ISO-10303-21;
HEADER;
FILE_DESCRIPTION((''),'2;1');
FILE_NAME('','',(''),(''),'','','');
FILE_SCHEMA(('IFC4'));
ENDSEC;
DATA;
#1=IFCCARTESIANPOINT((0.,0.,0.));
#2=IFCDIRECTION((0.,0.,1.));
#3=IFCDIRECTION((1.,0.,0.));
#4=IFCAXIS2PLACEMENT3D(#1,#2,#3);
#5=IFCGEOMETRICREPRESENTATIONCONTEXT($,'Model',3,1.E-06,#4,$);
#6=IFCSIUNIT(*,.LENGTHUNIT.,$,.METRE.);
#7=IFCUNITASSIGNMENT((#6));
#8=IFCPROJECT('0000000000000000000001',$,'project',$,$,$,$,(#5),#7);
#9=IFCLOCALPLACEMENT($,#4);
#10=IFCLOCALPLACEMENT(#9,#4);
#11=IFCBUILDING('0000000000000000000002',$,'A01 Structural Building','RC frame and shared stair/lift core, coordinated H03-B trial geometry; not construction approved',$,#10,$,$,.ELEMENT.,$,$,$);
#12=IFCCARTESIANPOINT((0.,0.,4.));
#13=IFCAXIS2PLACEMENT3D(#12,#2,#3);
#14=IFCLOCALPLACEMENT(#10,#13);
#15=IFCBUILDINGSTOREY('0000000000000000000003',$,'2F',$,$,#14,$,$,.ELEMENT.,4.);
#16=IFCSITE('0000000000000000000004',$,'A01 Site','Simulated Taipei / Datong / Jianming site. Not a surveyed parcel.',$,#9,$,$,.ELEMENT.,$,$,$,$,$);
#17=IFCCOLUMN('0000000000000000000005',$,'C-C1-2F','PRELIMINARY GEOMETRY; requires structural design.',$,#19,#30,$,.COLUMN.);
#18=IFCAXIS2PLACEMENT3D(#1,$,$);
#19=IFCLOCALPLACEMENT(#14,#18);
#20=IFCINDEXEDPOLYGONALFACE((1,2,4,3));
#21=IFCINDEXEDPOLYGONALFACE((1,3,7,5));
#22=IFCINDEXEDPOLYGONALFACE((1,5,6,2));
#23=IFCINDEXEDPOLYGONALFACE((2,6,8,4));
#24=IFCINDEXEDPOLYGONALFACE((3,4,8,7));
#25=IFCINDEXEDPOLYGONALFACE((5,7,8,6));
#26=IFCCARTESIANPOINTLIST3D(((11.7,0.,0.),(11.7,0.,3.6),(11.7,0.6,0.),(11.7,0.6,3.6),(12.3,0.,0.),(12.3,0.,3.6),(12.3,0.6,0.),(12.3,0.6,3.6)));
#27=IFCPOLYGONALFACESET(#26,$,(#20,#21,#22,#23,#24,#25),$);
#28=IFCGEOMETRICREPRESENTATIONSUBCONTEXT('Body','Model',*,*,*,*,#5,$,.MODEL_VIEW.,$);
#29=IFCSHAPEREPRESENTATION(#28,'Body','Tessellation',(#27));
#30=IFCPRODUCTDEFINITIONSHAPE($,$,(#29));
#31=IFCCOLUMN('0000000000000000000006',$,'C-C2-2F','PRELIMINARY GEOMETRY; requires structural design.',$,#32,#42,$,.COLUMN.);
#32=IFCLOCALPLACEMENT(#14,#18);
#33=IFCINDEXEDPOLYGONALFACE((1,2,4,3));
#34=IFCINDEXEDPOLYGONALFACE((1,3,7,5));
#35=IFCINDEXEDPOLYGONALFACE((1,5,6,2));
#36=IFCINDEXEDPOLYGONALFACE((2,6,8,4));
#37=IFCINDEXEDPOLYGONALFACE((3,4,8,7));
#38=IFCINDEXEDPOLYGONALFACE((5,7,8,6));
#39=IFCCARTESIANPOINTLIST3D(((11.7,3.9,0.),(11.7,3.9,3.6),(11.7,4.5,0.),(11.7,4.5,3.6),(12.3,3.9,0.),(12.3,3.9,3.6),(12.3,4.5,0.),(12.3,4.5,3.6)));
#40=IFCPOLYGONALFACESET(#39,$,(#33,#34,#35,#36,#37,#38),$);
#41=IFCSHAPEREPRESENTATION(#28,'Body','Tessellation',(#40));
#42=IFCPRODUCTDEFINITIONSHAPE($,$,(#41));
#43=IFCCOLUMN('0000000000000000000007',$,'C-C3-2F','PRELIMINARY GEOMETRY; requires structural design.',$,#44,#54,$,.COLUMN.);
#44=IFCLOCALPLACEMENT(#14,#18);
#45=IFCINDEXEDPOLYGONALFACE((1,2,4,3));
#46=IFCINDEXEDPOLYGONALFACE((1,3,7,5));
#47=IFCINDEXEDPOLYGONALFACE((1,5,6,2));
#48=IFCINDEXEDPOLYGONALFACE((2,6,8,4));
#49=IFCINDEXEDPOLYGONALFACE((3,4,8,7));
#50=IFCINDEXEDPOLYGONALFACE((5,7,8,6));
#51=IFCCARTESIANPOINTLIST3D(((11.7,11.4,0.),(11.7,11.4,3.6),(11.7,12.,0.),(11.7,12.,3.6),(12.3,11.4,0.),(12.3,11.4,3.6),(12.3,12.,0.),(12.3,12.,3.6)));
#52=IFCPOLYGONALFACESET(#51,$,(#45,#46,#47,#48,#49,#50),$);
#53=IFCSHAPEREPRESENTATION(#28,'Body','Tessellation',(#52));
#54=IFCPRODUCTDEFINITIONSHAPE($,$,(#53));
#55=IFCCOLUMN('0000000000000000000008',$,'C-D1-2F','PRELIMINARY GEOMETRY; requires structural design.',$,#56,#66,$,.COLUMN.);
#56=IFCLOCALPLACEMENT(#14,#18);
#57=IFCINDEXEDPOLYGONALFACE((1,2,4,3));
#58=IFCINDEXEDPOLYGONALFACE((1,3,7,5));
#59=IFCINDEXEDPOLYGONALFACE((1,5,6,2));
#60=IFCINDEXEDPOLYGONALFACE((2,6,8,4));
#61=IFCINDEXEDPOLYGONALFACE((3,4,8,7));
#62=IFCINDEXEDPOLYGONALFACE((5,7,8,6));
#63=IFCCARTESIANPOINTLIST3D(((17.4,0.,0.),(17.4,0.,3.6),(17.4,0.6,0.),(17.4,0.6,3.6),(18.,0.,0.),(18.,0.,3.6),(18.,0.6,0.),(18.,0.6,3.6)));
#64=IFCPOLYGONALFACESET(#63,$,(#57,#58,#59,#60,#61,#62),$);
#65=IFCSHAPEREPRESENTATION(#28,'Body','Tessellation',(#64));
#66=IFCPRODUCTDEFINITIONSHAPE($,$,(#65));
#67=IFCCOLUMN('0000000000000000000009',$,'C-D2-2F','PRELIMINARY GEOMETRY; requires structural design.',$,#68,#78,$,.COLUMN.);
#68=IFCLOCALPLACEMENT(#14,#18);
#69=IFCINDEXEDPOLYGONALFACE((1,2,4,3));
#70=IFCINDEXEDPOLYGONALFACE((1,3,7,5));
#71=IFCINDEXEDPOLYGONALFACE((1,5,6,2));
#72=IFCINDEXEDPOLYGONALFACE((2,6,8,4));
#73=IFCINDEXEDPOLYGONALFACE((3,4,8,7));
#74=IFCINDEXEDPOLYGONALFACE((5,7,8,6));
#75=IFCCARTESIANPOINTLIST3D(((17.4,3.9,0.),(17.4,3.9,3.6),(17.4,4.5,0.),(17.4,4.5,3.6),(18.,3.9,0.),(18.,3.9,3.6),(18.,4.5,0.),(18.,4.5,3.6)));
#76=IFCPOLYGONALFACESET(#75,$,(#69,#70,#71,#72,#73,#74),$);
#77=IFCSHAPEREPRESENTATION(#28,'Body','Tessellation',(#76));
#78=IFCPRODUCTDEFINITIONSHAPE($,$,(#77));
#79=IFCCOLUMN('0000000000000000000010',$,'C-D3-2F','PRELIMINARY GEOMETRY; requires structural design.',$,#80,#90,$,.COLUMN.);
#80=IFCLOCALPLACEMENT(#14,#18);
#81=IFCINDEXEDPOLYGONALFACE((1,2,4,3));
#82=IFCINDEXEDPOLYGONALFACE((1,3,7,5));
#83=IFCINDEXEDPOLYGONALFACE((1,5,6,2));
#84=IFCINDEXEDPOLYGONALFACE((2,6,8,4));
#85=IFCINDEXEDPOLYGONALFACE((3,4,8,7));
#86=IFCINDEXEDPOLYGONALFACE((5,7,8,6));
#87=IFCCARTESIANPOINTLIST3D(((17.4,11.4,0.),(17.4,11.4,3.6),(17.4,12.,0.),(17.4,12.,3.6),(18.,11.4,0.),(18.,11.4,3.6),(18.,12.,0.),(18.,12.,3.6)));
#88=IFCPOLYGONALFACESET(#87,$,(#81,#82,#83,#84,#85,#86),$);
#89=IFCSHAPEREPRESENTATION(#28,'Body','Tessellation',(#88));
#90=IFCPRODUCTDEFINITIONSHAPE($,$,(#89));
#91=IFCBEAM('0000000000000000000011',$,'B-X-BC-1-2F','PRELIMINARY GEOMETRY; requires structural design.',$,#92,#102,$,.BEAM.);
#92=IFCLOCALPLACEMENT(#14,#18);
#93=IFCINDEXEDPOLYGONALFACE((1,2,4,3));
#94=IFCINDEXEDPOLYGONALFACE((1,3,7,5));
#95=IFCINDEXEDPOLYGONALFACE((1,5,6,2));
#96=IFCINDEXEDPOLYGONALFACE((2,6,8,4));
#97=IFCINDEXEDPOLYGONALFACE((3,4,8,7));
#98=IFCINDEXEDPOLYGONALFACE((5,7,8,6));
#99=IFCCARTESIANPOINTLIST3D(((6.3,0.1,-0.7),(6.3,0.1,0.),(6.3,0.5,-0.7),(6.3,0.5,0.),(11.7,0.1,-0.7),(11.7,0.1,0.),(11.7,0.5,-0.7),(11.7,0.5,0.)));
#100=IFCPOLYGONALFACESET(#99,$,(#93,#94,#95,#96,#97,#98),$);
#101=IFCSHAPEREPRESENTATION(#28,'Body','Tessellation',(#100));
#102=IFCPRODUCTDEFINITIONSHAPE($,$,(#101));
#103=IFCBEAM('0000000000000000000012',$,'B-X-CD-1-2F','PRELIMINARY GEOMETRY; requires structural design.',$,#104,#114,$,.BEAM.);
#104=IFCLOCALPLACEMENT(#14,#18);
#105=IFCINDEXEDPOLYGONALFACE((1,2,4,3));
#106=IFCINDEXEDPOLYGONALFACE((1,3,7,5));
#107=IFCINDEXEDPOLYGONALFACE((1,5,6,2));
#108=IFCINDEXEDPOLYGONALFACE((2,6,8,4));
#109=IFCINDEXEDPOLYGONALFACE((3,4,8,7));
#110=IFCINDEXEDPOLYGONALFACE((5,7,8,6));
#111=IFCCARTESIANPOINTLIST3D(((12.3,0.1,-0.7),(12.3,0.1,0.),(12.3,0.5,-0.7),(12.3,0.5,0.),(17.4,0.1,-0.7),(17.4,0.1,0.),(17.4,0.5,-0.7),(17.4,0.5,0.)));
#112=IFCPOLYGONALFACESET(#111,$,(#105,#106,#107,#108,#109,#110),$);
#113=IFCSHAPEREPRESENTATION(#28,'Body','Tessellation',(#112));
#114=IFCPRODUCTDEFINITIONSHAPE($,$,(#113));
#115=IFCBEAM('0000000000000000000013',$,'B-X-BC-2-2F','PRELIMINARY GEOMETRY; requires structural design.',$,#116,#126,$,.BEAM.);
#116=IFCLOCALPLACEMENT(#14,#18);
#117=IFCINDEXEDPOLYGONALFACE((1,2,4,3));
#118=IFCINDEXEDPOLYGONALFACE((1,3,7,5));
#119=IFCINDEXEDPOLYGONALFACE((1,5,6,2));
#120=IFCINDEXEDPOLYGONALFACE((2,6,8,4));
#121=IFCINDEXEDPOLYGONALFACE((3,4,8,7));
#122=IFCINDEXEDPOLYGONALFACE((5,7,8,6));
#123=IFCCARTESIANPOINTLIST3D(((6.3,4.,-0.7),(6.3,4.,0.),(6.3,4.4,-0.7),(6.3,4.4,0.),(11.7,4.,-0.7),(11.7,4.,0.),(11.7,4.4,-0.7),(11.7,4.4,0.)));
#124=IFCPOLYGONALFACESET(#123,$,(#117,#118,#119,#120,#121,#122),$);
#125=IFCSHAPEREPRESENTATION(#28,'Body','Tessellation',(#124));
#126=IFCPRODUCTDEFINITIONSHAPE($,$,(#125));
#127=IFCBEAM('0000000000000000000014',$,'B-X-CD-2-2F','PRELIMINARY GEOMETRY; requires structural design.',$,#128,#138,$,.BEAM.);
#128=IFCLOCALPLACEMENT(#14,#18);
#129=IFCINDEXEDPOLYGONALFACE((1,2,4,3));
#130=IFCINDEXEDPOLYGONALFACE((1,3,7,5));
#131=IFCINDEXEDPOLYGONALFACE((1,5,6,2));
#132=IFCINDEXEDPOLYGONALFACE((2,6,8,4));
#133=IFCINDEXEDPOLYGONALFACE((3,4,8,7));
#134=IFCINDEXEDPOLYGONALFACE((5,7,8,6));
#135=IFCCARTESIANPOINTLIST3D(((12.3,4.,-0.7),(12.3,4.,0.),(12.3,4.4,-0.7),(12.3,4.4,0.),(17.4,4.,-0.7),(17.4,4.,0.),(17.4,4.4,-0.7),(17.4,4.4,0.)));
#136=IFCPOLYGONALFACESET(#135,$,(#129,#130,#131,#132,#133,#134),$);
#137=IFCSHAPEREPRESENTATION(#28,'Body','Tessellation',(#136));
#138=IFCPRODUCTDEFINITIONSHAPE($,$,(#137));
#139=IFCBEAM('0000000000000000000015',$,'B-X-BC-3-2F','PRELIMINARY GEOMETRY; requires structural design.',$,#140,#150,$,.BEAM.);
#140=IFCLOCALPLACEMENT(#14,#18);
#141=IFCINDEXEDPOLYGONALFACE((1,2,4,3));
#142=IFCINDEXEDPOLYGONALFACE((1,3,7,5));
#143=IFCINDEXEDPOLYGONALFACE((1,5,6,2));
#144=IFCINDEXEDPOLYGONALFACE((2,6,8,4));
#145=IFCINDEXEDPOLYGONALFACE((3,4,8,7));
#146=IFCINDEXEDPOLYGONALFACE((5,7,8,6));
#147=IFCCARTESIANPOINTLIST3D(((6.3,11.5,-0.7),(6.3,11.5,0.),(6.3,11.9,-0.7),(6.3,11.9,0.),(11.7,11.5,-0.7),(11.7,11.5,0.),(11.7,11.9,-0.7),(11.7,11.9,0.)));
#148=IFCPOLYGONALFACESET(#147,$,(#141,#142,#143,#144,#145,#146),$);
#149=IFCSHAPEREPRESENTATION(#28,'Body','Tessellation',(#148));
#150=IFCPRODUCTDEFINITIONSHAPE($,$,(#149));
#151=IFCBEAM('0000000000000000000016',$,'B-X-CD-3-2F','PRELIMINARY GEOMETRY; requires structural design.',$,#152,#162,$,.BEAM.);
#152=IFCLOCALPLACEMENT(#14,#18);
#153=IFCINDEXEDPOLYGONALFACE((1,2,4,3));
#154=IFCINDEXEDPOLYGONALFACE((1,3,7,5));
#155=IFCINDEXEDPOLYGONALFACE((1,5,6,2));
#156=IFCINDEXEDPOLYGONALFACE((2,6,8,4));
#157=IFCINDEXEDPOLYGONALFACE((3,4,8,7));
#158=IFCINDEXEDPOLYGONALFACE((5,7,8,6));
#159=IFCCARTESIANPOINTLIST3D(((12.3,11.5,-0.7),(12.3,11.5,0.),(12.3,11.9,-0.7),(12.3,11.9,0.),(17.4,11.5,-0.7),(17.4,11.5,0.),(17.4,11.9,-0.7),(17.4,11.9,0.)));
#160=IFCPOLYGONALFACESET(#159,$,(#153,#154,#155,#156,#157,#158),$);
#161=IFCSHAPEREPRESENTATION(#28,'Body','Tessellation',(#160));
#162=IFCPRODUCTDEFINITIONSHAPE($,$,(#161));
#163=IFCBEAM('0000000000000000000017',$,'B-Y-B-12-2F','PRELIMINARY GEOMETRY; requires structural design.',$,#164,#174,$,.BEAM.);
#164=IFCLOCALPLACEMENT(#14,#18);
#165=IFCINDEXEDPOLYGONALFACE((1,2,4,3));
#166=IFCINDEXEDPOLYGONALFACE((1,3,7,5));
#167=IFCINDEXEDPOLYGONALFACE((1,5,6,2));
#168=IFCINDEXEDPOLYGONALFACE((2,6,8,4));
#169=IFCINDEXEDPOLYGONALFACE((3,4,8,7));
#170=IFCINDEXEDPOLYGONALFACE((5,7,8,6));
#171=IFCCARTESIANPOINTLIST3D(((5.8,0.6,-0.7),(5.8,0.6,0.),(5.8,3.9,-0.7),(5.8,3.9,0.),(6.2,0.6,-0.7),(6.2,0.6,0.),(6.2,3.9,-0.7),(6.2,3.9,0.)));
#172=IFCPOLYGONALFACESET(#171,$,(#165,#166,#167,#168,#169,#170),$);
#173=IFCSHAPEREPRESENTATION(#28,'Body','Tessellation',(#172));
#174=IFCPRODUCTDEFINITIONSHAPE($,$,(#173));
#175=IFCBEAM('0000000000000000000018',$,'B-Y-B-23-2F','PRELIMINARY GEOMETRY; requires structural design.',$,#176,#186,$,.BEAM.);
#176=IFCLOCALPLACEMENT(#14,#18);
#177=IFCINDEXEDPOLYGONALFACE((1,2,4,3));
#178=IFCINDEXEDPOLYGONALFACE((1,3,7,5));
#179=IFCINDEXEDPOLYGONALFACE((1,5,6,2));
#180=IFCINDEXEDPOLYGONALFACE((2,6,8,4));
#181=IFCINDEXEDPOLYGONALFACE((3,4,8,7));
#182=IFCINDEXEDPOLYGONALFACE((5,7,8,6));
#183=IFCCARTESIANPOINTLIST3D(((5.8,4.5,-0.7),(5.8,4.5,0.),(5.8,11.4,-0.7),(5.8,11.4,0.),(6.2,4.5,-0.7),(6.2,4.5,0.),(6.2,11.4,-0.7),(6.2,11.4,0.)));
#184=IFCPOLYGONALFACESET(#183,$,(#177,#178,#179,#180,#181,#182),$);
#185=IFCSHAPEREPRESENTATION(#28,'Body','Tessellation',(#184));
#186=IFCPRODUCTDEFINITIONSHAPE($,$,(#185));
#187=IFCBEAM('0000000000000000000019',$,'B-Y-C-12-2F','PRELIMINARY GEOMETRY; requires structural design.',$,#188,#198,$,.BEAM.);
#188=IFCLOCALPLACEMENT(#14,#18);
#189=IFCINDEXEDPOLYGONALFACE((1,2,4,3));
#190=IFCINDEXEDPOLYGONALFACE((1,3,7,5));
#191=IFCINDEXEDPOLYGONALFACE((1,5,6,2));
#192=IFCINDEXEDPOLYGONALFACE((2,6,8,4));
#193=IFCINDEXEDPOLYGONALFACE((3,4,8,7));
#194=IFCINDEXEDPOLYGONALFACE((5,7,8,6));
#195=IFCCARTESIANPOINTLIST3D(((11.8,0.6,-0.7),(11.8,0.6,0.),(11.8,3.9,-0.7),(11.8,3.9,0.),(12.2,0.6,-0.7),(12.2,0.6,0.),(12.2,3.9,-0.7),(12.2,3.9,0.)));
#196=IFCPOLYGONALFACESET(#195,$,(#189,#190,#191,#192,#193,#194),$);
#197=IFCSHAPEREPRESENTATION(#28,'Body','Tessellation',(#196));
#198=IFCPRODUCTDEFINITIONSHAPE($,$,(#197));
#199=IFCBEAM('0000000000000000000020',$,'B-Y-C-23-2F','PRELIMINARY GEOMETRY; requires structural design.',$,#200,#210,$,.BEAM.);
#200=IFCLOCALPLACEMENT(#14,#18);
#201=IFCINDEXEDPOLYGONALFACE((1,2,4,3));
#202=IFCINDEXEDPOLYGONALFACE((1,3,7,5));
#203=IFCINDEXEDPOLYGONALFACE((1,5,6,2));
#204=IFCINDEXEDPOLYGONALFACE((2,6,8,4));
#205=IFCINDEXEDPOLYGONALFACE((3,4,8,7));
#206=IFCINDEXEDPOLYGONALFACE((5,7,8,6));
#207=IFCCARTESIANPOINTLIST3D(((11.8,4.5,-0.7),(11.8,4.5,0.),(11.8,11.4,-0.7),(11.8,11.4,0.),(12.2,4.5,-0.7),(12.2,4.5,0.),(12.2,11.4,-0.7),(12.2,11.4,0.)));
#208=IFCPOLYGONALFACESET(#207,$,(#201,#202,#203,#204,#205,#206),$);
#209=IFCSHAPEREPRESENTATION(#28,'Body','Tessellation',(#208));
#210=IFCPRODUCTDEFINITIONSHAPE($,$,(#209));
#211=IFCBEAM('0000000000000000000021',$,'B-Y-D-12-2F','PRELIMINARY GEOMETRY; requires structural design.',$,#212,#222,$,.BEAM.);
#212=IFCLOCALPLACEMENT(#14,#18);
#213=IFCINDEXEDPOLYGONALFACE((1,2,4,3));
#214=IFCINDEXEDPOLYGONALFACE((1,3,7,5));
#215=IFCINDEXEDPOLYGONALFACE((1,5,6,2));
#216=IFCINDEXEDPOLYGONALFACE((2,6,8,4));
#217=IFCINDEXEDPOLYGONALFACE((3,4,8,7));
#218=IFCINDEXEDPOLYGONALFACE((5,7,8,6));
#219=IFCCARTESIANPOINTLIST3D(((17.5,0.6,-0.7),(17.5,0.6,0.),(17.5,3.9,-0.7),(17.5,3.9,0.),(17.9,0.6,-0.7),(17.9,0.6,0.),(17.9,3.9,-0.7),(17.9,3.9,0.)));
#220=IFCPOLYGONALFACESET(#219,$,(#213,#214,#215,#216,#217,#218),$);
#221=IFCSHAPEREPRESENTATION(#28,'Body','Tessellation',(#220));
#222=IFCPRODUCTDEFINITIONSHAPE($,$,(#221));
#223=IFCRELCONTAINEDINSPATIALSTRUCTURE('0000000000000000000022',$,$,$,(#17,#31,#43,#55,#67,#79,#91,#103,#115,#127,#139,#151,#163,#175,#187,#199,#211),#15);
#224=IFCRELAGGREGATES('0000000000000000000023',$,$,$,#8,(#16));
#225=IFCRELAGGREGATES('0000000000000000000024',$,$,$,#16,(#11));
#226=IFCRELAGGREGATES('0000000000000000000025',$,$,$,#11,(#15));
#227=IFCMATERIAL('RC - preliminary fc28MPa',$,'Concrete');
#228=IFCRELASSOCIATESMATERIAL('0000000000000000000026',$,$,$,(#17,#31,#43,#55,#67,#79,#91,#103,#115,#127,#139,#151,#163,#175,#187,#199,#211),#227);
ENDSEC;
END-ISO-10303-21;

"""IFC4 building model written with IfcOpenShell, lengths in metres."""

from ifc_helpers import new_model, si_unit, frame, origin_with_axes, place, context, subcontext, project, spatial, rectangle, extrude, material, element, save


model = new_model("IFC4")

# Units and contexts
model_context = context("Model", 3, precision=1e-06, world=origin_with_axes())
body_context = subcontext(model_context, "Body", "Model", "MODEL_VIEW")
ifc_project = project(units=[si_unit("LENGTHUNIT", "METRE")], contexts=[model_context])

# Site, building, storey
site_placement = place(None, origin_with_axes())
site = spatial("IfcSite", under=ifc_project, at=site_placement, Name="A01 Site", Description="Simulated Taipei / Datong / Jianming site. Not a surveyed parcel.", CompositionType="ELEMENT")
building_placement = place(site_placement, origin_with_axes())
building = spatial("IfcBuilding", under=site, at=building_placement, Name="A01 Structural Building", Description="RC frame and shared stair/lift core, coordinated H03-B trial geometry; not construction approved", CompositionType="ELEMENT")
storey_placement = place(building_placement, frame((0.0, 0.0, 4.0), z_axis=(0.0, 0.0, 1.0), x_axis=(1.0, 0.0, 0.0)))
storey = spatial("IfcBuildingStorey", under=building, at=storey_placement, Name="2F", CompositionType="ELEMENT", Elevation=4.0)

# Columns
ifc_material = material(Name="RC - preliminary fc28MPa", Category="Concrete")
for number, where, z_axis, x_axis, name in (
    (1, (12.0, 0.3, 0.0), (0.0, 0.0, 1.0), (1.0, 0.0, 0.0), "C-C1-2F"),
    (2, (12.0, 4.2, 0.0), (0.0, 0.0, 1.0), (1.0, 0.0, 0.0), "C-C2-2F"),
    (3, (12.0, 11.7, 0.0), (0.0, 0.0, 1.0), (1.0, 0.0, 0.0), "C-C3-2F"),
    (4, (17.7, 0.3, 0.0), (0.0, 0.0, 1.0), (1.0, 0.0, 0.0), "C-D1-2F"),
    (5, (17.7, 4.2, 0.0), (0.0, 0.0, 1.0), (1.0, 0.0, 0.0), "C-D2-2F"),
    (6, (17.7, 11.7, 0.0), (0.0, 0.0, 1.0), (1.0, 0.0, 0.0), "C-D3-2F"),
):
    element("IfcColumn", number, at=place(storey_placement, frame(where, z_axis=z_axis, x_axis=x_axis)), inside=storey, material=ifc_material, Name=name, Description="PRELIMINARY GEOMETRY; requires structural design.", PredefinedType="COLUMN", context=body_context, shape_type="SweptSolid", body=[
        extrude(rectangle(XDim=0.6, YDim=0.6), origin_with_axes(), (0.0, 0.0, 1.0), 3.6),
    ])

# Beams
beam_1_placement = place(storey_placement, frame((9.0, 0.3, -0.7), z_axis=(0.0, 0.0, 1.0), x_axis=(1.0, 0.0, 0.0)))
element("IfcBeam", 7, at=beam_1_placement, inside=storey, material=ifc_material, Name="B-X-BC-1-2F", Description="PRELIMINARY GEOMETRY; requires structural design.", PredefinedType="BEAM", context=body_context, shape_type="SweptSolid", body=[
    extrude(rectangle(XDim=5.4, YDim=0.4), origin_with_axes(), (0.0, 0.0, 1.0), 0.7),
])
beam_2_placement = place(storey_placement, frame((14.85, 0.3, -0.7), z_axis=(0.0, 0.0, 1.0), x_axis=(1.0, 0.0, 0.0)))
element("IfcBeam", 8, at=beam_2_placement, inside=storey, material=ifc_material, Name="B-X-CD-1-2F", Description="PRELIMINARY GEOMETRY; requires structural design.", PredefinedType="BEAM", context=body_context, shape_type="SweptSolid", body=[
    extrude(rectangle(XDim=5.1, YDim=0.4), origin_with_axes(), (0.0, 0.0, 1.0), 0.7),
])
beam_3_placement = place(storey_placement, frame((9.0, 4.2, -0.7), z_axis=(0.0, 0.0, 1.0), x_axis=(1.0, 0.0, 0.0)))
element("IfcBeam", 9, at=beam_3_placement, inside=storey, material=ifc_material, Name="B-X-BC-2-2F", Description="PRELIMINARY GEOMETRY; requires structural design.", PredefinedType="BEAM", context=body_context, shape_type="SweptSolid", body=[
    extrude(rectangle(XDim=5.4, YDim=0.4), origin_with_axes(), (0.0, 0.0, 1.0), 0.7),
])
beam_4_placement = place(storey_placement, frame((14.85, 4.2, -0.7), z_axis=(0.0, 0.0, 1.0), x_axis=(1.0, 0.0, 0.0)))
element("IfcBeam", 10, at=beam_4_placement, inside=storey, material=ifc_material, Name="B-X-CD-2-2F", Description="PRELIMINARY GEOMETRY; requires structural design.", PredefinedType="BEAM", context=body_context, shape_type="SweptSolid", body=[
    extrude(rectangle(XDim=5.1, YDim=0.4), origin_with_axes(), (0.0, 0.0, 1.0), 0.7),
])
beam_5_placement = place(storey_placement, frame((9.0, 11.7, -0.7), z_axis=(0.0, 0.0, 1.0), x_axis=(1.0, 0.0, 0.0)))
element("IfcBeam", 11, at=beam_5_placement, inside=storey, material=ifc_material, Name="B-X-BC-3-2F", Description="PRELIMINARY GEOMETRY; requires structural design.", PredefinedType="BEAM", context=body_context, shape_type="SweptSolid", body=[
    extrude(rectangle(XDim=5.4, YDim=0.4), origin_with_axes(), (0.0, 0.0, 1.0), 0.7),
])
beam_6_placement = place(storey_placement, frame((14.85, 11.7, -0.7), z_axis=(0.0, 0.0, 1.0), x_axis=(1.0, 0.0, 0.0)))
element("IfcBeam", 12, at=beam_6_placement, inside=storey, material=ifc_material, Name="B-X-CD-3-2F", Description="PRELIMINARY GEOMETRY; requires structural design.", PredefinedType="BEAM", context=body_context, shape_type="SweptSolid", body=[
    extrude(rectangle(XDim=5.1, YDim=0.4), origin_with_axes(), (0.0, 0.0, 1.0), 0.7),
])
beam_7_placement = place(storey_placement, frame((6.0, 2.25, -0.7), z_axis=(0.0, 0.0, 1.0), x_axis=(1.0, 0.0, 0.0)))
element("IfcBeam", 13, at=beam_7_placement, inside=storey, material=ifc_material, Name="B-Y-B-12-2F", Description="PRELIMINARY GEOMETRY; requires structural design.", PredefinedType="BEAM", context=body_context, shape_type="SweptSolid", body=[
    extrude(rectangle(XDim=0.4, YDim=3.3), origin_with_axes(), (0.0, 0.0, 1.0), 0.7),
])
beam_8_placement = place(storey_placement, frame((6.0, 7.95, -0.7), z_axis=(0.0, 0.0, 1.0), x_axis=(1.0, 0.0, 0.0)))
element("IfcBeam", 14, at=beam_8_placement, inside=storey, material=ifc_material, Name="B-Y-B-23-2F", Description="PRELIMINARY GEOMETRY; requires structural design.", PredefinedType="BEAM", context=body_context, shape_type="SweptSolid", body=[
    extrude(rectangle(XDim=0.4, YDim=6.9), origin_with_axes(), (0.0, 0.0, 1.0), 0.7),
])
beam_9_placement = place(storey_placement, frame((12.0, 2.25, -0.7), z_axis=(0.0, 0.0, 1.0), x_axis=(1.0, 0.0, 0.0)))
element("IfcBeam", 15, at=beam_9_placement, inside=storey, material=ifc_material, Name="B-Y-C-12-2F", Description="PRELIMINARY GEOMETRY; requires structural design.", PredefinedType="BEAM", context=body_context, shape_type="SweptSolid", body=[
    extrude(rectangle(XDim=0.4, YDim=3.3), origin_with_axes(), (0.0, 0.0, 1.0), 0.7),
])
beam_10_placement = place(storey_placement, frame((12.0, 7.95, -0.7), z_axis=(0.0, 0.0, 1.0), x_axis=(1.0, 0.0, 0.0)))
element("IfcBeam", 16, at=beam_10_placement, inside=storey, material=ifc_material, Name="B-Y-C-23-2F", Description="PRELIMINARY GEOMETRY; requires structural design.", PredefinedType="BEAM", context=body_context, shape_type="SweptSolid", body=[
    extrude(rectangle(XDim=0.4, YDim=6.9), origin_with_axes(), (0.0, 0.0, 1.0), 0.7),
])
beam_11_placement = place(storey_placement, frame((17.7, 2.25, -0.7), z_axis=(0.0, 0.0, 1.0), x_axis=(1.0, 0.0, 0.0)))
element("IfcBeam", 17, at=beam_11_placement, inside=storey, material=ifc_material, Name="B-Y-D-12-2F", Description="PRELIMINARY GEOMETRY; requires structural design.", PredefinedType="BEAM", context=body_context, shape_type="SweptSolid", body=[
    extrude(rectangle(XDim=0.4, YDim=3.3), origin_with_axes(), (0.0, 0.0, 1.0), 0.7),
])

save(model, "model.ifc")
